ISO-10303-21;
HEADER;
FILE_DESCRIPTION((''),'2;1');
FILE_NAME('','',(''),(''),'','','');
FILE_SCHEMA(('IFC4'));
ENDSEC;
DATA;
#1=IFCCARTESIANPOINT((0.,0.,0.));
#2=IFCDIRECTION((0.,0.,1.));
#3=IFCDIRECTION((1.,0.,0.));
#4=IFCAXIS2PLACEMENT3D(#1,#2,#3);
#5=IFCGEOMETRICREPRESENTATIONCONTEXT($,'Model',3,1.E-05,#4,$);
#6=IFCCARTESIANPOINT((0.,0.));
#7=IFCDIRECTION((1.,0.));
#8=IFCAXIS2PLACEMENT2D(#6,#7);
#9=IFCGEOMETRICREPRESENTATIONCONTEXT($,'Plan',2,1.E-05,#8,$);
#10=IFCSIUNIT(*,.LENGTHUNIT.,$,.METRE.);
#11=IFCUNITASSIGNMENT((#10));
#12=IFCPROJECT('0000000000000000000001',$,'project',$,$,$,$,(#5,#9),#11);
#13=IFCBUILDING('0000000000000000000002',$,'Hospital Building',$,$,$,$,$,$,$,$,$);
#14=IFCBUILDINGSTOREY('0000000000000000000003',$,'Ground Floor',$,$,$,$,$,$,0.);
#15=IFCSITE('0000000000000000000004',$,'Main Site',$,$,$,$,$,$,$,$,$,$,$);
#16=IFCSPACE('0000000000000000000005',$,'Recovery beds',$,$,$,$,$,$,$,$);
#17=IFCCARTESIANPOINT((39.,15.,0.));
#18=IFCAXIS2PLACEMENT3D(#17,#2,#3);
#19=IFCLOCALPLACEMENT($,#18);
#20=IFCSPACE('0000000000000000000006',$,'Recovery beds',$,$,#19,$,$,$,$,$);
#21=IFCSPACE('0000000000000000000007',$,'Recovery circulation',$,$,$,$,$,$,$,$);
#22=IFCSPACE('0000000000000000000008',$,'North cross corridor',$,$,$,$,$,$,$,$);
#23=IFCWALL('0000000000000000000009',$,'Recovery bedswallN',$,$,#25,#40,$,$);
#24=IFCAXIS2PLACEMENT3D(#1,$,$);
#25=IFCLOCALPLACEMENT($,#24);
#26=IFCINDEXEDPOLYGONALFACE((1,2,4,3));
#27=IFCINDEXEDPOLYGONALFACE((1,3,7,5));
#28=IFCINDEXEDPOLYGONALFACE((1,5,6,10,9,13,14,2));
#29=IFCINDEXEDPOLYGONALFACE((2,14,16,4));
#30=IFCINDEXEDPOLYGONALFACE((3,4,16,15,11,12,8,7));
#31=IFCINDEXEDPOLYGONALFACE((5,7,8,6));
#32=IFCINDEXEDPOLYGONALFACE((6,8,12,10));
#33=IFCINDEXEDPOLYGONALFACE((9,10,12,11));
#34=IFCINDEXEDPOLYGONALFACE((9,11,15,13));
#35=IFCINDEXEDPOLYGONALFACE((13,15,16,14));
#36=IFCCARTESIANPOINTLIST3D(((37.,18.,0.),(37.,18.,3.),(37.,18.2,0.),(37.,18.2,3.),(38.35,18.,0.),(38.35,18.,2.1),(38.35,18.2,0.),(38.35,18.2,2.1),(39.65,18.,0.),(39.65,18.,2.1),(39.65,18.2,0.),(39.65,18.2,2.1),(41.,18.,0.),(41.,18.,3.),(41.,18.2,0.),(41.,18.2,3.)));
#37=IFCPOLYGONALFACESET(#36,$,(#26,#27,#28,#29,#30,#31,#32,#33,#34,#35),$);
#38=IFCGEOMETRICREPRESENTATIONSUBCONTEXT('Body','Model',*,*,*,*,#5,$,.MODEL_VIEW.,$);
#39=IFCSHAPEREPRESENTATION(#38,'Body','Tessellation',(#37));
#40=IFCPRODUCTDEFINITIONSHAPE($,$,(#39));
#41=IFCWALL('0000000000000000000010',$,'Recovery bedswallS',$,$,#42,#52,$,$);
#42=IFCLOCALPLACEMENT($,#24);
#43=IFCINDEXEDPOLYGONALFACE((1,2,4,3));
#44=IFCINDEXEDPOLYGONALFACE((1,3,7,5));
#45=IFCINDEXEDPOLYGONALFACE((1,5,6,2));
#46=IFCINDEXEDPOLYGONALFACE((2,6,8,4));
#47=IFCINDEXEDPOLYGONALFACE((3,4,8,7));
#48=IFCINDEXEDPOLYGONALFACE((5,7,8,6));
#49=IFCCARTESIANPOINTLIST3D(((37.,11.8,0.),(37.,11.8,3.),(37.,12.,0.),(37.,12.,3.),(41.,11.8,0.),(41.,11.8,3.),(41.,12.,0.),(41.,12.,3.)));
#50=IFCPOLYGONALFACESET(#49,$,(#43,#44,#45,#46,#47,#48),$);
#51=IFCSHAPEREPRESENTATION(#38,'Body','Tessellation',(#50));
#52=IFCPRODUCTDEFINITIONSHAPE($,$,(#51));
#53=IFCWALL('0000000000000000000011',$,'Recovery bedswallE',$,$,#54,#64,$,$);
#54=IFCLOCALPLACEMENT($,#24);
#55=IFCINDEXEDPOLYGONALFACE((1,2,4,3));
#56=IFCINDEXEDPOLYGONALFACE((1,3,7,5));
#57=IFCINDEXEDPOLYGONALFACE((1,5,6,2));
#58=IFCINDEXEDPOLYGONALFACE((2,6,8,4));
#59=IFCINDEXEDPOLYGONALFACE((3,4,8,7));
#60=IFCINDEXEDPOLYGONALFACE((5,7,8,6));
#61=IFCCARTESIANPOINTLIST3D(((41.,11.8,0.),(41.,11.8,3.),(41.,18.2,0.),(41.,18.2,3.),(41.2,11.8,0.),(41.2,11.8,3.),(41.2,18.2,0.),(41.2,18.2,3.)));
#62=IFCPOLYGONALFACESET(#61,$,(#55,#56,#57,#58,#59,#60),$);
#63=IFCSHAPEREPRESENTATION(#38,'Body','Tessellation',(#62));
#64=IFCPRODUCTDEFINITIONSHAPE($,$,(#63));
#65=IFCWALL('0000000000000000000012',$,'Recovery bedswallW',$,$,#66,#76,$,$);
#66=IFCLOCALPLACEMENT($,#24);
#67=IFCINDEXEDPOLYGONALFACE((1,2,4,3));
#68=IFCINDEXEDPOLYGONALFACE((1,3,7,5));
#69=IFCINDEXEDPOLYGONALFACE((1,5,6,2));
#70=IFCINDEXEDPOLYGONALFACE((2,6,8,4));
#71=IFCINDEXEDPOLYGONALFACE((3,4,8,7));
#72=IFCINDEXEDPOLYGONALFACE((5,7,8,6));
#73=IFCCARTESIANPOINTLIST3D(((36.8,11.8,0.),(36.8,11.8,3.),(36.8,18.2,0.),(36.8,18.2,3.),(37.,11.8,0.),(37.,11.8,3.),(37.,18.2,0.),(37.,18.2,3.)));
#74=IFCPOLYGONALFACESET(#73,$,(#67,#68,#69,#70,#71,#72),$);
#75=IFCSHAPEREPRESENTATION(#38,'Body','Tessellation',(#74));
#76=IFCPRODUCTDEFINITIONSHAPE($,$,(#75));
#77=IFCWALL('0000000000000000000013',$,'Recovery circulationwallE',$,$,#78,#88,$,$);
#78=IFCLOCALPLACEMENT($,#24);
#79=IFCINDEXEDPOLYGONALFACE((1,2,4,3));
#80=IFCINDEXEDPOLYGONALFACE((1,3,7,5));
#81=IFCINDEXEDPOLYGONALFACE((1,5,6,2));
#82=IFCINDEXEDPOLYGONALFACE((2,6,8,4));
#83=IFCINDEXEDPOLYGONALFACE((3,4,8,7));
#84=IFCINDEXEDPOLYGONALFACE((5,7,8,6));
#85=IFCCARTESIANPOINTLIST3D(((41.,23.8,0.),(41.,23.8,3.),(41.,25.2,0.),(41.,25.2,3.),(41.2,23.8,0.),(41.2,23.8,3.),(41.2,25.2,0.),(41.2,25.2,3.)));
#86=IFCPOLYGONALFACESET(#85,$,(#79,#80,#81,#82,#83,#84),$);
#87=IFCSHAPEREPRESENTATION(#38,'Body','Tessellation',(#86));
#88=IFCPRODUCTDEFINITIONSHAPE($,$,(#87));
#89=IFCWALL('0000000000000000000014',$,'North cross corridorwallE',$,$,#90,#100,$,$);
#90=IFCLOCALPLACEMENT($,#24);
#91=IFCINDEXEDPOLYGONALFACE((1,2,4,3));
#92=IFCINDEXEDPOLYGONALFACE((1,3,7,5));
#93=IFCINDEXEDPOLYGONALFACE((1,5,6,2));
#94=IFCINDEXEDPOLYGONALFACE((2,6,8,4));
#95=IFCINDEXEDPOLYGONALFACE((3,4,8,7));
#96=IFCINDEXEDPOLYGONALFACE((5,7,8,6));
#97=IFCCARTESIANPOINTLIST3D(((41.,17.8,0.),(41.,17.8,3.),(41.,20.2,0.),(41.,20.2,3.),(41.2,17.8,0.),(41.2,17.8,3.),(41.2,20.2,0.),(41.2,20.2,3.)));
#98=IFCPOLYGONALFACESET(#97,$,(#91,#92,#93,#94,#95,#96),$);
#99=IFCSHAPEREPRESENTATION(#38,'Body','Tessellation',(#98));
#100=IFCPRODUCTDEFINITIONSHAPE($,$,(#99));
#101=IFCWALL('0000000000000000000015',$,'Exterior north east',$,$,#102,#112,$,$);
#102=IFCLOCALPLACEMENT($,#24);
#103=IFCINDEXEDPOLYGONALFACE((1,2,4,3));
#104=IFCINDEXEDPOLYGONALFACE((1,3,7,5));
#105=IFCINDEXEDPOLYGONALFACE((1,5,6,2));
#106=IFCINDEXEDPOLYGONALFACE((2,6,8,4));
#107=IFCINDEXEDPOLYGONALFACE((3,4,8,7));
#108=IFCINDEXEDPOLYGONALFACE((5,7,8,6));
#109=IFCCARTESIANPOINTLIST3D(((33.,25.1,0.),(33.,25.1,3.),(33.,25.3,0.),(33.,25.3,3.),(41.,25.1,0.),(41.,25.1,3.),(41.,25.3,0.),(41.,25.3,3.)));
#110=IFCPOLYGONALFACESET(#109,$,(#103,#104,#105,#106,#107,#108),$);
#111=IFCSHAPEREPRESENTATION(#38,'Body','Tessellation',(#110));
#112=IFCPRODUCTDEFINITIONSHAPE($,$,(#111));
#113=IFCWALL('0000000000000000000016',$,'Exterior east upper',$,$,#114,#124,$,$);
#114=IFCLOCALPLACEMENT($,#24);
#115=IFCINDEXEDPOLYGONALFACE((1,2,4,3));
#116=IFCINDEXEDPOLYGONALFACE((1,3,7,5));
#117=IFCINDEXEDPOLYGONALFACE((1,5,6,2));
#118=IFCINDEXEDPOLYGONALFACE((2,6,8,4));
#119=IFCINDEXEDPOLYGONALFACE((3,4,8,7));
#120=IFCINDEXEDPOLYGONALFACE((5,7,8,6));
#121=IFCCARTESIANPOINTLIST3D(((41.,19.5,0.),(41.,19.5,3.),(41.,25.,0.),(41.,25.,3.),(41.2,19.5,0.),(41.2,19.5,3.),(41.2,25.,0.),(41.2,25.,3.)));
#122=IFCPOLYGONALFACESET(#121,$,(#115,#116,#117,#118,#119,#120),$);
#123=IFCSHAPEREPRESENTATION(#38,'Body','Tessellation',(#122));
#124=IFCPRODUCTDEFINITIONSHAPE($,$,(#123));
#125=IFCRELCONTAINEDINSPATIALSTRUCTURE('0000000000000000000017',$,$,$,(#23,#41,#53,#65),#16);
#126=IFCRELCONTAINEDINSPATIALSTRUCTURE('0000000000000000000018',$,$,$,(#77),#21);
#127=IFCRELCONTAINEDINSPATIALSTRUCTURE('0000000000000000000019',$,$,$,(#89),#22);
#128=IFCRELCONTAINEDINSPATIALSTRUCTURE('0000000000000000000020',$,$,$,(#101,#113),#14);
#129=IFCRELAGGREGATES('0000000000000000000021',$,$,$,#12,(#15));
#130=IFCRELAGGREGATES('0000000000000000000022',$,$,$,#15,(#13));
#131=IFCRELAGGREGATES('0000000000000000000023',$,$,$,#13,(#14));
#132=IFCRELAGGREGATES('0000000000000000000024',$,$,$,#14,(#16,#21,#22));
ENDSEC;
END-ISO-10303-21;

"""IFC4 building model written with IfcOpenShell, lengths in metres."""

from ifc_helpers import new_model, si_unit, frame, origin_with_axes, origin_2d_with_axis, place, context, subcontext, project, spatial, indexed_curve, outline, extrude, element, save


model = new_model("IFC4")

# Units and contexts
model_context = context("Model", 3, precision=1e-05, world=origin_with_axes())
plan_context = context("Plan", 2, precision=1e-05, world=origin_2d_with_axis())
body_context = subcontext(model_context, "Body", "Model", "MODEL_VIEW")
ifc_project = project(units=[si_unit("LENGTHUNIT", "METRE")], contexts=[model_context, plan_context])

# Site, building, storey
site = spatial("IfcSite", under=ifc_project, Name="Main Site")
building = spatial("IfcBuilding", under=site, Name="Hospital Building")
storey = spatial("IfcBuildingStorey", under=building, Name="Ground Floor", Elevation=0.0)

# Shared definitions
space_1 = spatial("IfcSpace", under=storey, Name="Recovery beds")

# Wall
wall_1_placement = place(None, frame((37.0, 18.0, 0.0), z_axis=(0.0, 0.0, 1.0), x_axis=(1.0, 0.0, 0.0)))
wall_1 = element("IfcWall", 1, at=wall_1_placement, inside=space_1, Name="Recovery bedswallN", context=body_context, shape_type="SweptSolid", body=[
    extrude(outline(indexed_curve([(0.0, 0.0), (0.0, 0.2), (4.0, 0.2), (4.0, 0.0), (0.0, 0.0)], self_intersect=False)), origin_with_axes(), (0.0, 0.0, 1.0), 3.0),
])

# Shared definitions
space_2_placement = place(None, frame((39.0, 15.0, 0.0), z_axis=(0.0, 0.0, 1.0), x_axis=(1.0, 0.0, 0.0)))
space_2 = spatial("IfcSpace", at=space_2_placement, Name="Recovery beds")

# Opening
opening_1_placement = place(wall_1_placement, frame((1.35, -0.1, 0.0), z_axis=(0.0, 0.0, 1.0), x_axis=(1.0, 0.0, 0.0)))
element("IfcOpeningElement", 2, at=opening_1_placement, inside=space_2, cuts=wall_1, context=body_context, shape_type="SweptSolid", body=[
    extrude(outline(indexed_curve([(0.0, 0.0), (0.0, 0.4), (1.3, 0.4), (1.3, 0.0), (0.0, 0.0)], self_intersect=False)), origin_with_axes(), (0.0, 0.0, 1.0), 2.1),
])

# Walls
wall_2_placement = place(None, frame((37.0, 11.8, 0.0), z_axis=(0.0, 0.0, 1.0), x_axis=(1.0, 0.0, 0.0)))
element("IfcWall", 3, at=wall_2_placement, inside=space_1, Name="Recovery bedswallS", context=body_context, shape_type="SweptSolid", body=[
    extrude(outline(indexed_curve([(0.0, 0.0), (0.0, 0.2), (4.0, 0.2), (4.0, 0.0), (0.0, 0.0)], self_intersect=False)), origin_with_axes(), (0.0, 0.0, 1.0), 3.0),
])
for number, where, z_axis, x_axis, name in (
    (4, (41.2, 11.8, 0.0), (0.0, 0.0, 1.0), (0.0, 1.0, 0.0), "Recovery bedswallE"),
    (5, (37.0, 11.8, 0.0), (0.0, 0.0, 1.0), (0.0, 1.0, 0.0), "Recovery bedswallW"),
):
    element("IfcWall", number, at=place(None, frame(where, z_axis=z_axis, x_axis=x_axis)), inside=space_1, Name=name, context=body_context, shape_type="SweptSolid", body=[
        extrude(outline(indexed_curve([(0.0, 0.0), (0.0, 0.2), (6.4, 0.2), (6.4, 0.0), (0.0, 0.0)], self_intersect=False)), origin_with_axes(), (0.0, 0.0, 1.0), 3.0),
    ])

# Shared definitions
space_3 = spatial("IfcSpace", under=storey, Name="Recovery circulation")

# Wall
wall_3_placement = place(None, frame((41.2, 23.8, 0.0), z_axis=(0.0, 0.0, 1.0), x_axis=(0.0, 1.0, 0.0)))
element("IfcWall", 6, at=wall_3_placement, inside=space_3, Name="Recovery circulationwallE", context=body_context, shape_type="SweptSolid", body=[
    extrude(outline(indexed_curve([(0.0, 0.0), (0.0, 0.2), (1.4, 0.2), (1.4, 0.0), (0.0, 0.0)], self_intersect=False)), origin_with_axes(), (0.0, 0.0, 1.0), 3.0),
])

# Shared definitions
space_4 = spatial("IfcSpace", under=storey, Name="North cross corridor")

# Walls
wall_4_placement = place(None, frame((41.2, 17.8, 0.0), z_axis=(0.0, 0.0, 1.0), x_axis=(0.0, 1.0, 0.0)))
element("IfcWall", 7, at=wall_4_placement, inside=space_4, Name="North cross corridorwallE", context=body_context, shape_type="SweptSolid", body=[
    extrude(outline(indexed_curve([(0.0, 0.0), (0.0, 0.2), (2.4, 0.2), (2.4, 0.0), (0.0, 0.0)], self_intersect=False)), origin_with_axes(), (0.0, 0.0, 1.0), 3.0),
])
wall_5_placement = place(None, frame((33.0, 25.1, 0.0), z_axis=(0.0, 0.0, 1.0), x_axis=(1.0, 0.0, 0.0)))
element("IfcWall", 8, at=wall_5_placement, inside=storey, Name="Exterior north east", context=body_context, shape_type="SweptSolid", body=[
    extrude(outline(indexed_curve([(0.0, 0.0), (0.0, 0.2), (8.0, 0.2), (8.0, 0.0), (0.0, 0.0)], self_intersect=False)), origin_with_axes(), (0.0, 0.0, 1.0), 3.0),
])
wall_6_placement = place(None, frame((41.2, 19.5, 0.0), z_axis=(0.0, 0.0, 1.0), x_axis=(0.0, 1.0, 0.0)))
element("IfcWall", 9, at=wall_6_placement, inside=storey, Name="Exterior east upper", context=body_context, shape_type="SweptSolid", body=[
    extrude(outline(indexed_curve([(0.0, 0.0), (0.0, 0.2), (5.5, 0.2), (5.5, 0.0), (0.0, 0.0)], self_intersect=False)), origin_with_axes(), (0.0, 0.0, 1.0), 3.0),
])

save(model, "model.ifc")
